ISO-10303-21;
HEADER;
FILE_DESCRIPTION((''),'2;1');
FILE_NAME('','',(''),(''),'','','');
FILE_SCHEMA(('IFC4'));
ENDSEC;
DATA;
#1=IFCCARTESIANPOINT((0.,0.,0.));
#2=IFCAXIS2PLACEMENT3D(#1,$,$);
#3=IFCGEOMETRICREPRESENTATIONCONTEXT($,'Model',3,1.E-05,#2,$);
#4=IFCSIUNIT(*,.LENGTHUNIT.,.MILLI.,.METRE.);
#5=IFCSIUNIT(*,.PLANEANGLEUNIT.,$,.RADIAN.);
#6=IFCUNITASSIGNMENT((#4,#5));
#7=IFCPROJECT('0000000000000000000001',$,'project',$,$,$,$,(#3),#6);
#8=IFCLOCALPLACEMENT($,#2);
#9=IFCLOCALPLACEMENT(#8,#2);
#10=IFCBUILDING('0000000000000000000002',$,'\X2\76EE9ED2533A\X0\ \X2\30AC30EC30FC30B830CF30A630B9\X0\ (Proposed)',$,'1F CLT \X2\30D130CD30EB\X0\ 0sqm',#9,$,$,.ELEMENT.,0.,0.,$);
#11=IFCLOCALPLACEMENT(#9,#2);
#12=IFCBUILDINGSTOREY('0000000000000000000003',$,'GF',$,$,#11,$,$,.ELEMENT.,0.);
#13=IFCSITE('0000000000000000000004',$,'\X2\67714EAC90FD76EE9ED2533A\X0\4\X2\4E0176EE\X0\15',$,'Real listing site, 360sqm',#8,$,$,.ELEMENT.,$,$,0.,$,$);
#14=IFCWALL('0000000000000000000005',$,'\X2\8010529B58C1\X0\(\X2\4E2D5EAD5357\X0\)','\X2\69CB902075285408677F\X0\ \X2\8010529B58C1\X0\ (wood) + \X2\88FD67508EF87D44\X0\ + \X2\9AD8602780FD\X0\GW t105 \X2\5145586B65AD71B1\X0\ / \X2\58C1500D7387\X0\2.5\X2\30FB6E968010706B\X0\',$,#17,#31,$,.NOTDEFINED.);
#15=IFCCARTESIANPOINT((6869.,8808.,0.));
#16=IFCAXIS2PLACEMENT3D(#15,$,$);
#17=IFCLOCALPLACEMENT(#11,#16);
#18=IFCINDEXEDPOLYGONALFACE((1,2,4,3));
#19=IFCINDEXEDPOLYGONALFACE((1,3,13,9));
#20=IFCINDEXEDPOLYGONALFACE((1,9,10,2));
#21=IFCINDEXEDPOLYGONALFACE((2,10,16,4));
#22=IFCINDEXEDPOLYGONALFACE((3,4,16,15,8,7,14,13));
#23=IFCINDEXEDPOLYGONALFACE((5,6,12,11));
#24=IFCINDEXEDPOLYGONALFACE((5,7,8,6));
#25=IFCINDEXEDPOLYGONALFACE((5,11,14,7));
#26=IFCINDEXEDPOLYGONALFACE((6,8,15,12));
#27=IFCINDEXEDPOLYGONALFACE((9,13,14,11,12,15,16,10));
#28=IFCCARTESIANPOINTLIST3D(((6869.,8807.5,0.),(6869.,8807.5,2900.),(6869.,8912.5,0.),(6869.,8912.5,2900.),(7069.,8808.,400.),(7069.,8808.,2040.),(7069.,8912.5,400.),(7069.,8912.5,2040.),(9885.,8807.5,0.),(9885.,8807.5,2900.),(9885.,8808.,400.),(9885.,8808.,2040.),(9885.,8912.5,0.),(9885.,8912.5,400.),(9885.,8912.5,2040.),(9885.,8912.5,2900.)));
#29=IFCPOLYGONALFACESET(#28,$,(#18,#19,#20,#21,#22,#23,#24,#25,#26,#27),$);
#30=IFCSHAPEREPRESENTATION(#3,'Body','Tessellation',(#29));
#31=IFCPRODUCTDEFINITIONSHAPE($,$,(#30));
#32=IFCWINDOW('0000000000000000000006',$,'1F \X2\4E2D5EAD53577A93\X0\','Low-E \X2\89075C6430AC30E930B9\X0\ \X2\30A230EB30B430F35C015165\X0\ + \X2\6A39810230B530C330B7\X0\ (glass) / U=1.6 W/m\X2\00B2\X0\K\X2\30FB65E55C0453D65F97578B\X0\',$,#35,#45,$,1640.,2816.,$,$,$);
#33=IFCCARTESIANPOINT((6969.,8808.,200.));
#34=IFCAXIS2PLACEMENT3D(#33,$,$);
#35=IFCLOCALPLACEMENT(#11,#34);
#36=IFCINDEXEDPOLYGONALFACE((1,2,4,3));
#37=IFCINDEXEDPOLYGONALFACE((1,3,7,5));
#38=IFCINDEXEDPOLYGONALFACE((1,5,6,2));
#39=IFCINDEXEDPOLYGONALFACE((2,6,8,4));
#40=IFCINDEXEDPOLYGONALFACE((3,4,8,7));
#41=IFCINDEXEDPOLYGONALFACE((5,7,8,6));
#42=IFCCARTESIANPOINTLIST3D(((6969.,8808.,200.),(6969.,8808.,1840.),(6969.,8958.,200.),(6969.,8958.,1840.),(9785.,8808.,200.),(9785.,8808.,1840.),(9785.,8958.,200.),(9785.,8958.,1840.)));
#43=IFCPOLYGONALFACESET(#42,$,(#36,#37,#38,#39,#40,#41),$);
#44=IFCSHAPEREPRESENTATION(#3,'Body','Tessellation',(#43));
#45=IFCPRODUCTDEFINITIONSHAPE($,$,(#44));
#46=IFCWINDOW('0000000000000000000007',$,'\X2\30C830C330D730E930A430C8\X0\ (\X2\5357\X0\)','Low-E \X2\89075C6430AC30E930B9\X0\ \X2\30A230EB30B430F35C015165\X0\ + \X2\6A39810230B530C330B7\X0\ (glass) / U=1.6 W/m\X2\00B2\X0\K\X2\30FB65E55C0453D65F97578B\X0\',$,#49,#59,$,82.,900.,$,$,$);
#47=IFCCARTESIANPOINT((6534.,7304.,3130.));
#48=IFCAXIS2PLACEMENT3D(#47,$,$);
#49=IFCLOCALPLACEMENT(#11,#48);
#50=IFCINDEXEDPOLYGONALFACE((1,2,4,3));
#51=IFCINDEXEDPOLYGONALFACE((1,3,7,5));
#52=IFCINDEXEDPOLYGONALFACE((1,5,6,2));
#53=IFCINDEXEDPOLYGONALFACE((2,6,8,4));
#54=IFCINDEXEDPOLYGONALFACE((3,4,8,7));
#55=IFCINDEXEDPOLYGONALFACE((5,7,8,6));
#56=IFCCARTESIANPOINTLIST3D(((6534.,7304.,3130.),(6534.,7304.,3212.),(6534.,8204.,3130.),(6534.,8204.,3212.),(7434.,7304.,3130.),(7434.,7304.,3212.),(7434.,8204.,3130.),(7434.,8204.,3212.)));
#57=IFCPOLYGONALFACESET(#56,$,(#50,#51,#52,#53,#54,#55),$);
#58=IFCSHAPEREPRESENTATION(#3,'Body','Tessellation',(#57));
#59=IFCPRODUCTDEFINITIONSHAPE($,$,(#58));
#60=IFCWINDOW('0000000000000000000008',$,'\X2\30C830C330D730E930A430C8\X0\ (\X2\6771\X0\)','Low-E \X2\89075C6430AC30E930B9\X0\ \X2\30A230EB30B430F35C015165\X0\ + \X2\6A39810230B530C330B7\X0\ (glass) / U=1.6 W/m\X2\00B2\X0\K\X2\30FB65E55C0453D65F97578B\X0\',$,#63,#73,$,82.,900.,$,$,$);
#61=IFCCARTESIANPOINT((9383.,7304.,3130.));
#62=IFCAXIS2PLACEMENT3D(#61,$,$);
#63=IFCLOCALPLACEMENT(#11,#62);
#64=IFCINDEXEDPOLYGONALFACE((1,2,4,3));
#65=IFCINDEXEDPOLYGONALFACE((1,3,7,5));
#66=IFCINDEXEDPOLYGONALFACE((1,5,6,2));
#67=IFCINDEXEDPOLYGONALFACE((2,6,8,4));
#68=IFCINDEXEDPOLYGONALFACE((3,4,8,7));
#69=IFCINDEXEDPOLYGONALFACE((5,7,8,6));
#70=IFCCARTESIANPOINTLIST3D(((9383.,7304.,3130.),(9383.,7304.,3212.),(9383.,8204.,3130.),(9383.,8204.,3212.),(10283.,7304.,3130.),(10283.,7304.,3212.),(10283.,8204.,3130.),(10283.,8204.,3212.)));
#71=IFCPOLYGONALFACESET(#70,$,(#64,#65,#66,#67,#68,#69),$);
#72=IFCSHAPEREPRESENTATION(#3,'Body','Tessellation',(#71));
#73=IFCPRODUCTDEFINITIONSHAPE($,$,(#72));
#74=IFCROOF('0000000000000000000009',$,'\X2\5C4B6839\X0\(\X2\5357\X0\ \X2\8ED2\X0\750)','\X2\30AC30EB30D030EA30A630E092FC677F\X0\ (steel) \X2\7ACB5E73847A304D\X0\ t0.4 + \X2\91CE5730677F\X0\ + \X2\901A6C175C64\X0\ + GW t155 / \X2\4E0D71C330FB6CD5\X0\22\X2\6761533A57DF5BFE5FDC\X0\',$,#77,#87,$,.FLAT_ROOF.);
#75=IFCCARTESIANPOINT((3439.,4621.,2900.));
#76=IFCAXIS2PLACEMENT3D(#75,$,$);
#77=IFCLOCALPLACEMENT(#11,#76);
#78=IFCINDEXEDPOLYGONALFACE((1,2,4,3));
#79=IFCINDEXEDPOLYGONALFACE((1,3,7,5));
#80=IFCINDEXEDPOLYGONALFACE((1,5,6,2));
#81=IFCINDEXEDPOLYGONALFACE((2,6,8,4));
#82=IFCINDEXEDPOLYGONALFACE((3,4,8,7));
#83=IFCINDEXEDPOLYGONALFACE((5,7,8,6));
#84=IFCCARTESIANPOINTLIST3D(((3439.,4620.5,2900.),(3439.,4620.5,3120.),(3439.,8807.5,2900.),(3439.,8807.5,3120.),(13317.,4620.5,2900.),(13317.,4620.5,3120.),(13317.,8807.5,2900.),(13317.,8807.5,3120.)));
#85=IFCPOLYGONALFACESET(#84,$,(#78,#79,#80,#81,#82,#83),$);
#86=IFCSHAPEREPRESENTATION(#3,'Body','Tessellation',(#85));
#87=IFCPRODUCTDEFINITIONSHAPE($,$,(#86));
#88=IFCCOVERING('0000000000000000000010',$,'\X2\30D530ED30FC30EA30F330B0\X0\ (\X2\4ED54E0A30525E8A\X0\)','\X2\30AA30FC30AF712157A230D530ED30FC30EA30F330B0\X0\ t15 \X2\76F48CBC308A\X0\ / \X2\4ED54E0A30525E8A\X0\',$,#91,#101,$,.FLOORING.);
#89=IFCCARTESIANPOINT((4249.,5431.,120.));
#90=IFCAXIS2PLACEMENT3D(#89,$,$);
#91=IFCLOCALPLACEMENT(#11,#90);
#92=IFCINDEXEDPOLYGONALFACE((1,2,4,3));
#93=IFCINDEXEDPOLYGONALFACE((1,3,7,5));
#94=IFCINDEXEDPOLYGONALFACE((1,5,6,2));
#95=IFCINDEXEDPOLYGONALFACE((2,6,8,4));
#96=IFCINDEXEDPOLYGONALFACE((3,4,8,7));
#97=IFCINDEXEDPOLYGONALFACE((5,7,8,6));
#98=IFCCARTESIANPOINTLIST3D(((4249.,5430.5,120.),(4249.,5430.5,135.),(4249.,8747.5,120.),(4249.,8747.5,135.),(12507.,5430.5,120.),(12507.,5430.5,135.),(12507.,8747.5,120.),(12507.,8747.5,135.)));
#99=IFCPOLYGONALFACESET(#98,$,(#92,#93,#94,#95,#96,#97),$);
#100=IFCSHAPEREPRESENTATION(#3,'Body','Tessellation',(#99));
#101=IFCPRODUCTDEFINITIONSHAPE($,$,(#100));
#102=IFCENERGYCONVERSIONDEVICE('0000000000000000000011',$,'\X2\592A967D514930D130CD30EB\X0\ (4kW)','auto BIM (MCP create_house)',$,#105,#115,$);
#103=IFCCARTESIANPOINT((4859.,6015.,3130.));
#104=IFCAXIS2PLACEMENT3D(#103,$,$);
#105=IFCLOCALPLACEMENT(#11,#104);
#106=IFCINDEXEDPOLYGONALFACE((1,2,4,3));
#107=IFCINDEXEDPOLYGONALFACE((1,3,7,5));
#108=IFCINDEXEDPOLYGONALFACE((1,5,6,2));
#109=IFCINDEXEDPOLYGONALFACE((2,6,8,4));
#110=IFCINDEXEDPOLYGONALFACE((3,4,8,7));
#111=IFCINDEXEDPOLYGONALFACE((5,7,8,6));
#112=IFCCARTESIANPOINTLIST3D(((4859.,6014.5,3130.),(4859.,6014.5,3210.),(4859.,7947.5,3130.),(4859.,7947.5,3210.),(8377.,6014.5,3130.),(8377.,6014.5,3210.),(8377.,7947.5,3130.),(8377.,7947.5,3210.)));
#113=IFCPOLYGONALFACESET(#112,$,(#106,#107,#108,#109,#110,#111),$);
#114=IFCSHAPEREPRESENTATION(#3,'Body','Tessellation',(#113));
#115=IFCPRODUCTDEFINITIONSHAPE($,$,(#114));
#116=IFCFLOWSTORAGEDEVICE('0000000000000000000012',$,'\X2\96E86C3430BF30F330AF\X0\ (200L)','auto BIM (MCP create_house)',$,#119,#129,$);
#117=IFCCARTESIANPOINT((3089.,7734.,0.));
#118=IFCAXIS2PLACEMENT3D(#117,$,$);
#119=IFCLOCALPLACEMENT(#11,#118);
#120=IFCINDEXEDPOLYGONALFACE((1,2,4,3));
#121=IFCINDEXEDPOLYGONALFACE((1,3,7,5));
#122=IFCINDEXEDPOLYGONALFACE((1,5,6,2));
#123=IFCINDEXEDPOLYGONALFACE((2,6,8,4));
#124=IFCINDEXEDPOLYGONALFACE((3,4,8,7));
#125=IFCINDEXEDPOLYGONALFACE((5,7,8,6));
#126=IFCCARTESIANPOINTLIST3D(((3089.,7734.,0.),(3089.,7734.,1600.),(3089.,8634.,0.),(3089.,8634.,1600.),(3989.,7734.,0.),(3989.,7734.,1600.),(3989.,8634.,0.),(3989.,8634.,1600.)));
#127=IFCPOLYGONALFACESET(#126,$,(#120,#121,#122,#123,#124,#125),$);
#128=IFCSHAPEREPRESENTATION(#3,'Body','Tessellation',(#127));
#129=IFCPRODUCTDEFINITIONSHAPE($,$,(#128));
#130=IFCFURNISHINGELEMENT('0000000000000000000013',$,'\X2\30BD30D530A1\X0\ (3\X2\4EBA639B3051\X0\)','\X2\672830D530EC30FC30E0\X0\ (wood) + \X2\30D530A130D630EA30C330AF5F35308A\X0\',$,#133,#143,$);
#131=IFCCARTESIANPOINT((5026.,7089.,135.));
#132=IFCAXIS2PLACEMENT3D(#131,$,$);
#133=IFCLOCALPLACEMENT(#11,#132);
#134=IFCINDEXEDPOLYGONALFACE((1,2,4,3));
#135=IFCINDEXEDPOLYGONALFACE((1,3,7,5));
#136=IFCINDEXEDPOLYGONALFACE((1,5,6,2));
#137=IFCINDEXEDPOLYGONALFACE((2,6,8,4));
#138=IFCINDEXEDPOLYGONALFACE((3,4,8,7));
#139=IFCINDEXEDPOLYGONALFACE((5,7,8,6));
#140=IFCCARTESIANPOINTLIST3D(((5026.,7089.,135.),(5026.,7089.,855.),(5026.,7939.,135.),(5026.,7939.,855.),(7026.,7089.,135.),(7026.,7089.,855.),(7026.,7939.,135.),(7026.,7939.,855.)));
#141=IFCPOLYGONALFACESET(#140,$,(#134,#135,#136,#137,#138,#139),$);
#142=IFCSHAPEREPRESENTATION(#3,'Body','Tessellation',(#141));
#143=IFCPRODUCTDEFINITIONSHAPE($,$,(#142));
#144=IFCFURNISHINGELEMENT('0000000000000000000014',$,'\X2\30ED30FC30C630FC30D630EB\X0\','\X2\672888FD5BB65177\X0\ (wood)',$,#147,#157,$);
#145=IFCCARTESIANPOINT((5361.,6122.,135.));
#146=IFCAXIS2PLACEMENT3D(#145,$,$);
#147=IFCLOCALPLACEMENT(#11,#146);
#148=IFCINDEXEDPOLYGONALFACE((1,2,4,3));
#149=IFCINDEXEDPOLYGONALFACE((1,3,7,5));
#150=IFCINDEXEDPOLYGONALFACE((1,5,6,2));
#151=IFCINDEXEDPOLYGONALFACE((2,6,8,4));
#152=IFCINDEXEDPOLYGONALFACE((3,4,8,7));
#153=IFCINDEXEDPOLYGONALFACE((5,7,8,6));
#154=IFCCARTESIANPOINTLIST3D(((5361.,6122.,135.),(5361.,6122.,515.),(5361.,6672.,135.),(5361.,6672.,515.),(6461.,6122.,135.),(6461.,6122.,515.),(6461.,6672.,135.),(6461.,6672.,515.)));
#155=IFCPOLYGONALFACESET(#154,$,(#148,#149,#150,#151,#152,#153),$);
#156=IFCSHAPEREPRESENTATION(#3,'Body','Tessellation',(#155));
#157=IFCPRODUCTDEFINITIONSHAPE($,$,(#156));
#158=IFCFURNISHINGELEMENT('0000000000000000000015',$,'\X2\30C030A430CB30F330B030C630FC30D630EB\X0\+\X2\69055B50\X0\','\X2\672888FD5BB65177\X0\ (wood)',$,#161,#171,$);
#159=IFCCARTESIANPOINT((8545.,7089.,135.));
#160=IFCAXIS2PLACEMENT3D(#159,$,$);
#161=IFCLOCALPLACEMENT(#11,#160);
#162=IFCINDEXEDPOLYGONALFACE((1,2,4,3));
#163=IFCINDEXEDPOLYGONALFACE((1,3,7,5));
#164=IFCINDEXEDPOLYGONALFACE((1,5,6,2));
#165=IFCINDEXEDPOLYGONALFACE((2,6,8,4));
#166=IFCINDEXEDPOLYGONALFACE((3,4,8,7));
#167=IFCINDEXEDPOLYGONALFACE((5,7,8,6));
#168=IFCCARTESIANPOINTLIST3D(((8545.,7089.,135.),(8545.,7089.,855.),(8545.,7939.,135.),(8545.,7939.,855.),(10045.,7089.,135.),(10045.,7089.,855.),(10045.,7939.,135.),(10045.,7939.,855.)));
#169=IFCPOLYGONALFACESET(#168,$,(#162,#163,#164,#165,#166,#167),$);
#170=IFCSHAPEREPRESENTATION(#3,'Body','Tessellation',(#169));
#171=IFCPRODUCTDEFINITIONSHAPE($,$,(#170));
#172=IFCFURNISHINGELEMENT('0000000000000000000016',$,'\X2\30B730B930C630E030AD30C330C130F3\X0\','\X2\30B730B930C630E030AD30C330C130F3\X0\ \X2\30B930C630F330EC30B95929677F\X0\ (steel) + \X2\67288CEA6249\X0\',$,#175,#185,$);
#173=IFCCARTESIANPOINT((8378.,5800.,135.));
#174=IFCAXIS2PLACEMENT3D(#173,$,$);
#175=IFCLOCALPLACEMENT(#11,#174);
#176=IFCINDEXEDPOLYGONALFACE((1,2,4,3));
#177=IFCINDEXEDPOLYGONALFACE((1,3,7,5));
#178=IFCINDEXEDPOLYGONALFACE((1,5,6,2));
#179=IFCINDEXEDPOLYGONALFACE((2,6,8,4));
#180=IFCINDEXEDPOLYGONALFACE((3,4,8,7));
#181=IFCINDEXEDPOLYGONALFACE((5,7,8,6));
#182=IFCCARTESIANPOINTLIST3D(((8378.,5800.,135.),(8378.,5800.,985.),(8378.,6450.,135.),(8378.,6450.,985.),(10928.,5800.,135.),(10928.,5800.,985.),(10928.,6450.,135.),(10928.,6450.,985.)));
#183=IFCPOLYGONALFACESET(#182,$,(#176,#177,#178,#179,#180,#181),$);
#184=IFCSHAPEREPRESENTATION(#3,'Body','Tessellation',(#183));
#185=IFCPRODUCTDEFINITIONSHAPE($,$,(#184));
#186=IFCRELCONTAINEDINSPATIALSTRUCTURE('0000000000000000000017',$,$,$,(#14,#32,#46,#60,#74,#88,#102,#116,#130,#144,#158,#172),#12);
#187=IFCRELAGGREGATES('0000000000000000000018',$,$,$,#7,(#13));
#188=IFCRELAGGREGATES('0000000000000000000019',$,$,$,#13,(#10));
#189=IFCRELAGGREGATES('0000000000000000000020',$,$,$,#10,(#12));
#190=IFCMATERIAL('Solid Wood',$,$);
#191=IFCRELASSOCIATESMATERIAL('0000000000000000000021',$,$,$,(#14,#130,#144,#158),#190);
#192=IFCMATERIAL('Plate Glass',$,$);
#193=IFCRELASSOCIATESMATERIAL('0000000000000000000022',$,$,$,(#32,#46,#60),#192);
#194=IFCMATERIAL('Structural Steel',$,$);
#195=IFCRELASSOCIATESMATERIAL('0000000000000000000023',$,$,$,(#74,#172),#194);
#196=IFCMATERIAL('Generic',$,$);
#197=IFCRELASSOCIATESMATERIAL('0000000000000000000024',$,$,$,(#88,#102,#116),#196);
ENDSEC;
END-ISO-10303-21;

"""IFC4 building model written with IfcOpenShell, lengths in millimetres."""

from ifc_helpers import new_model, si_unit, frame, frame_2d, origin, place, context, project, spatial, rectangle, extrude, material, element, fill, save


model = new_model("IFC4")

# Units and contexts
model_context = context("Model", 3, precision=1e-05, world=origin())
ifc_project = project(units=[si_unit("LENGTHUNIT", "METRE", prefix="MILLI"), si_unit("PLANEANGLEUNIT", "RADIAN")], contexts=[model_context])

# Site, building, storey
site_placement = place(None, origin())
site = spatial("IfcSite", under=ifc_project, at=site_placement, Name="東京都目黒区4丁目15", ObjectType="Real listing site, 360sqm", CompositionType="ELEMENT", RefElevation=0.0)
building_placement = place(site_placement, origin())
building = spatial("IfcBuilding", under=site, at=building_placement, Name="目黒区 ガレージハウス (Proposed)", ObjectType="1F CLT パネル 0sqm", CompositionType="ELEMENT", ElevationOfRefHeight=0.0, ElevationOfTerrain=0.0)
storey_placement = place(building_placement, origin())
storey = spatial("IfcBuildingStorey", under=building, at=storey_placement, Name="GF", CompositionType="ELEMENT", Elevation=0.0)

# Shared definitions
ifc_material_1 = material(Name="Solid Wood")

# Shared definitions
ifc_material_2 = material(Name="Plate Glass")

# Wall, opening, window
wall_1_placement = place(storey_placement, frame((6869.0, 8808.0, 0.0)))
wall_1 = element("IfcWall", 1, at=wall_1_placement, inside=storey, material=ifc_material_1, Name="耐力壁(中庭南)", Description="構造用合板 耐力壁 (wood) + 製材軸組 + 高性能GW t105 充填断熱 / 壁倍率2.5・準耐火", PredefinedType="NOTDEFINED", context=model_context, shape_type="SweptSolid", body=[
    extrude(rectangle(XDim=3016.0, YDim=105.0, at=frame_2d((1508.0, 52.0))), frame((6869.0, 8808.0, 0.0)), (0.0, 0.0, 1.0), 2900.0),
])
opening_1_placement = place(storey_placement, frame((6969.0, 8808.0, 200.0)))
opening_1 = element("IfcOpeningElement", 2, at=opening_1_placement, cuts=wall_1, PredefinedType="NOTDEFINED", context=model_context, shape_type="SweptSolid", body=[
    extrude(rectangle(XDim=2816.0, YDim=150.0, at=frame_2d((1408.0, 75.0))), frame((6969.0, 8808.0, 200.0)), (0.0, 0.0, 1.0), 1640.0),
])
window_1_placement = place(storey_placement, frame((6969.0, 8808.0, 200.0)))
window_1 = element("IfcWindow", 3, at=window_1_placement, inside=storey, material=ifc_material_2, Name="1F 中庭南窓", Description="Low-E 複層ガラス アルゴン封入 + 樹脂サッシ (glass) / U=1.6 W/m²K・日射取得型", OverallHeight=1640.0, OverallWidth=2816.0, context=model_context, shape_type="SweptSolid", body=[
    extrude(rectangle(XDim=2816.0, YDim=150.0, at=frame_2d((1408.0, 75.0))), frame((6969.0, 8808.0, 200.0)), (0.0, 0.0, 1.0), 1640.0),
])
fill(opening_1, window_1)

# Windows
window_2_placement = place(storey_placement, frame((6534.0, 7304.0, 3130.0)))
element("IfcWindow", 4, at=window_2_placement, inside=storey, material=ifc_material_2, Name="トップライト (南)", Description="Low-E 複層ガラス アルゴン封入 + 樹脂サッシ (glass) / U=1.6 W/m²K・日射取得型", OverallHeight=82.0, OverallWidth=900.0, context=model_context, shape_type="SweptSolid", body=[
    extrude(rectangle(XDim=900.0, YDim=900.0, at=frame_2d((450.0, 450.0))), frame((6534.0, 7304.0, 3130.0)), (0.0, 0.0, 1.0), 82.0),
])
window_3_placement = place(storey_placement, frame((9383.0, 7304.0, 3130.0)))
element("IfcWindow", 5, at=window_3_placement, inside=storey, material=ifc_material_2, Name="トップライト (東)", Description="Low-E 複層ガラス アルゴン封入 + 樹脂サッシ (glass) / U=1.6 W/m²K・日射取得型", OverallHeight=82.0, OverallWidth=900.0, context=model_context, shape_type="SweptSolid", body=[
    extrude(rectangle(XDim=900.0, YDim=900.0, at=frame_2d((450.0, 450.0))), frame((9383.0, 7304.0, 3130.0)), (0.0, 0.0, 1.0), 82.0),
])

# Roof
ifc_material_3 = material(Name="Structural Steel")
roof_placement = place(storey_placement, frame((3439.0, 4621.0, 2900.0)))
element("IfcRoof", 6, at=roof_placement, inside=storey, material=ifc_material_3, Name="屋根(南 軒750)", Description="ガルバリウム鋼板 (steel) 立平葺き t0.4 + 野地板 + 通気層 + GW t155 / 不燃・法22条区域対応", PredefinedType="FLAT_ROOF", context=model_context, shape_type="SweptSolid", body=[
    extrude(rectangle(XDim=9878.0, YDim=4187.0, at=frame_2d((4939.0, 2093.0))), frame((3439.0, 4621.0, 2900.0)), (0.0, 0.0, 1.0), 220.0),
])

# Covering
ifc_material_4 = material(Name="Generic")
covering_placement = place(storey_placement, frame((4249.0, 5431.0, 120.0)))
element("IfcCovering", 7, at=covering_placement, inside=storey, material=ifc_material_4, Name="フローリング (仕上げ床)", Description="オーク無垢フローリング t15 直貼り / 仕上げ床", PredefinedType="FLOORING", context=model_context, shape_type="SweptSolid", body=[
    extrude(rectangle(XDim=8258.0, YDim=3317.0, at=frame_2d((4129.0, 1658.0))), frame((4249.0, 5431.0, 120.0)), (0.0, 0.0, 1.0), 15.0),
])

# Energy conversion device
energy_conversion_device_placement = place(storey_placement, frame((4859.0, 6015.0, 3130.0)))
element("IfcEnergyConversionDevice", 8, at=energy_conversion_device_placement, inside=storey, material=ifc_material_4, Name="太陽光パネル (4kW)", Description="auto BIM (MCP create_house)", context=model_context, shape_type="SweptSolid", body=[
    extrude(rectangle(XDim=3518.0, YDim=1933.0, at=frame_2d((1759.0, 966.0))), frame((4859.0, 6015.0, 3130.0)), (0.0, 0.0, 1.0), 80.0),
])

# Flow storage device
flow_storage_device_placement = place(storey_placement, frame((3089.0, 7734.0, 0.0)))
element("IfcFlowStorageDevice", 9, at=flow_storage_device_placement, inside=storey, material=ifc_material_4, Name="雨水タンク (200L)", Description="auto BIM (MCP create_house)", context=model_context, shape_type="SweptSolid", body=[
    extrude(rectangle(XDim=900.0, YDim=900.0, at=frame_2d((450.0, 450.0))), frame((3089.0, 7734.0, 0.0)), (0.0, 0.0, 1.0), 1600.0),
])

# Furnishing elements
furnishing_1_placement = place(storey_placement, frame((5026.0, 7089.0, 135.0)))
element("IfcFurnishingElement", 10, at=furnishing_1_placement, inside=storey, material=ifc_material_1, Name="ソファ (3人掛け)", Description="木フレーム (wood) + ファブリック張り", context=model_context, shape_type="SweptSolid", body=[
    extrude(rectangle(XDim=2000.0, YDim=850.0, at=frame_2d((1000.0, 425.0))), frame((5026.0, 7089.0, 135.0)), (0.0, 0.0, 1.0), 720.0),
])
furnishing_2_placement = place(storey_placement, frame((5361.0, 6122.0, 135.0)))
element("IfcFurnishingElement", 11, at=furnishing_2_placement, inside=storey, material=ifc_material_1, Name="ローテーブル", Description="木製家具 (wood)", context=model_context, shape_type="SweptSolid", body=[
    extrude(rectangle(XDim=1100.0, YDim=550.0, at=frame_2d((550.0, 275.0))), frame((5361.0, 6122.0, 135.0)), (0.0, 0.0, 1.0), 380.0),
])
furnishing_3_placement = place(storey_placement, frame((8545.0, 7089.0, 135.0)))
element("IfcFurnishingElement", 12, at=furnishing_3_placement, inside=storey, material=ifc_material_1, Name="ダイニングテーブル+椅子", Description="木製家具 (wood)", context=model_context, shape_type="SweptSolid", body=[
    extrude(rectangle(XDim=1500.0, YDim=850.0, at=frame_2d((750.0, 425.0))), frame((8545.0, 7089.0, 135.0)), (0.0, 0.0, 1.0), 720.0),
])
furnishing_4_placement = place(storey_placement, frame((8378.0, 5800.0, 135.0)))
element("IfcFurnishingElement", 13, at=furnishing_4_placement, inside=storey, material=ifc_material_3, Name="システムキッチン", Description="システムキッチン ステンレス天板 (steel) + 木質扉", context=model_context, shape_type="SweptSolid", body=[
    extrude(rectangle(XDim=2550.0, YDim=650.0, at=frame_2d((1275.0, 325.0))), frame((8378.0, 5800.0, 135.0)), (0.0, 0.0, 1.0), 850.0),
])

save(model, "model.ifc")
